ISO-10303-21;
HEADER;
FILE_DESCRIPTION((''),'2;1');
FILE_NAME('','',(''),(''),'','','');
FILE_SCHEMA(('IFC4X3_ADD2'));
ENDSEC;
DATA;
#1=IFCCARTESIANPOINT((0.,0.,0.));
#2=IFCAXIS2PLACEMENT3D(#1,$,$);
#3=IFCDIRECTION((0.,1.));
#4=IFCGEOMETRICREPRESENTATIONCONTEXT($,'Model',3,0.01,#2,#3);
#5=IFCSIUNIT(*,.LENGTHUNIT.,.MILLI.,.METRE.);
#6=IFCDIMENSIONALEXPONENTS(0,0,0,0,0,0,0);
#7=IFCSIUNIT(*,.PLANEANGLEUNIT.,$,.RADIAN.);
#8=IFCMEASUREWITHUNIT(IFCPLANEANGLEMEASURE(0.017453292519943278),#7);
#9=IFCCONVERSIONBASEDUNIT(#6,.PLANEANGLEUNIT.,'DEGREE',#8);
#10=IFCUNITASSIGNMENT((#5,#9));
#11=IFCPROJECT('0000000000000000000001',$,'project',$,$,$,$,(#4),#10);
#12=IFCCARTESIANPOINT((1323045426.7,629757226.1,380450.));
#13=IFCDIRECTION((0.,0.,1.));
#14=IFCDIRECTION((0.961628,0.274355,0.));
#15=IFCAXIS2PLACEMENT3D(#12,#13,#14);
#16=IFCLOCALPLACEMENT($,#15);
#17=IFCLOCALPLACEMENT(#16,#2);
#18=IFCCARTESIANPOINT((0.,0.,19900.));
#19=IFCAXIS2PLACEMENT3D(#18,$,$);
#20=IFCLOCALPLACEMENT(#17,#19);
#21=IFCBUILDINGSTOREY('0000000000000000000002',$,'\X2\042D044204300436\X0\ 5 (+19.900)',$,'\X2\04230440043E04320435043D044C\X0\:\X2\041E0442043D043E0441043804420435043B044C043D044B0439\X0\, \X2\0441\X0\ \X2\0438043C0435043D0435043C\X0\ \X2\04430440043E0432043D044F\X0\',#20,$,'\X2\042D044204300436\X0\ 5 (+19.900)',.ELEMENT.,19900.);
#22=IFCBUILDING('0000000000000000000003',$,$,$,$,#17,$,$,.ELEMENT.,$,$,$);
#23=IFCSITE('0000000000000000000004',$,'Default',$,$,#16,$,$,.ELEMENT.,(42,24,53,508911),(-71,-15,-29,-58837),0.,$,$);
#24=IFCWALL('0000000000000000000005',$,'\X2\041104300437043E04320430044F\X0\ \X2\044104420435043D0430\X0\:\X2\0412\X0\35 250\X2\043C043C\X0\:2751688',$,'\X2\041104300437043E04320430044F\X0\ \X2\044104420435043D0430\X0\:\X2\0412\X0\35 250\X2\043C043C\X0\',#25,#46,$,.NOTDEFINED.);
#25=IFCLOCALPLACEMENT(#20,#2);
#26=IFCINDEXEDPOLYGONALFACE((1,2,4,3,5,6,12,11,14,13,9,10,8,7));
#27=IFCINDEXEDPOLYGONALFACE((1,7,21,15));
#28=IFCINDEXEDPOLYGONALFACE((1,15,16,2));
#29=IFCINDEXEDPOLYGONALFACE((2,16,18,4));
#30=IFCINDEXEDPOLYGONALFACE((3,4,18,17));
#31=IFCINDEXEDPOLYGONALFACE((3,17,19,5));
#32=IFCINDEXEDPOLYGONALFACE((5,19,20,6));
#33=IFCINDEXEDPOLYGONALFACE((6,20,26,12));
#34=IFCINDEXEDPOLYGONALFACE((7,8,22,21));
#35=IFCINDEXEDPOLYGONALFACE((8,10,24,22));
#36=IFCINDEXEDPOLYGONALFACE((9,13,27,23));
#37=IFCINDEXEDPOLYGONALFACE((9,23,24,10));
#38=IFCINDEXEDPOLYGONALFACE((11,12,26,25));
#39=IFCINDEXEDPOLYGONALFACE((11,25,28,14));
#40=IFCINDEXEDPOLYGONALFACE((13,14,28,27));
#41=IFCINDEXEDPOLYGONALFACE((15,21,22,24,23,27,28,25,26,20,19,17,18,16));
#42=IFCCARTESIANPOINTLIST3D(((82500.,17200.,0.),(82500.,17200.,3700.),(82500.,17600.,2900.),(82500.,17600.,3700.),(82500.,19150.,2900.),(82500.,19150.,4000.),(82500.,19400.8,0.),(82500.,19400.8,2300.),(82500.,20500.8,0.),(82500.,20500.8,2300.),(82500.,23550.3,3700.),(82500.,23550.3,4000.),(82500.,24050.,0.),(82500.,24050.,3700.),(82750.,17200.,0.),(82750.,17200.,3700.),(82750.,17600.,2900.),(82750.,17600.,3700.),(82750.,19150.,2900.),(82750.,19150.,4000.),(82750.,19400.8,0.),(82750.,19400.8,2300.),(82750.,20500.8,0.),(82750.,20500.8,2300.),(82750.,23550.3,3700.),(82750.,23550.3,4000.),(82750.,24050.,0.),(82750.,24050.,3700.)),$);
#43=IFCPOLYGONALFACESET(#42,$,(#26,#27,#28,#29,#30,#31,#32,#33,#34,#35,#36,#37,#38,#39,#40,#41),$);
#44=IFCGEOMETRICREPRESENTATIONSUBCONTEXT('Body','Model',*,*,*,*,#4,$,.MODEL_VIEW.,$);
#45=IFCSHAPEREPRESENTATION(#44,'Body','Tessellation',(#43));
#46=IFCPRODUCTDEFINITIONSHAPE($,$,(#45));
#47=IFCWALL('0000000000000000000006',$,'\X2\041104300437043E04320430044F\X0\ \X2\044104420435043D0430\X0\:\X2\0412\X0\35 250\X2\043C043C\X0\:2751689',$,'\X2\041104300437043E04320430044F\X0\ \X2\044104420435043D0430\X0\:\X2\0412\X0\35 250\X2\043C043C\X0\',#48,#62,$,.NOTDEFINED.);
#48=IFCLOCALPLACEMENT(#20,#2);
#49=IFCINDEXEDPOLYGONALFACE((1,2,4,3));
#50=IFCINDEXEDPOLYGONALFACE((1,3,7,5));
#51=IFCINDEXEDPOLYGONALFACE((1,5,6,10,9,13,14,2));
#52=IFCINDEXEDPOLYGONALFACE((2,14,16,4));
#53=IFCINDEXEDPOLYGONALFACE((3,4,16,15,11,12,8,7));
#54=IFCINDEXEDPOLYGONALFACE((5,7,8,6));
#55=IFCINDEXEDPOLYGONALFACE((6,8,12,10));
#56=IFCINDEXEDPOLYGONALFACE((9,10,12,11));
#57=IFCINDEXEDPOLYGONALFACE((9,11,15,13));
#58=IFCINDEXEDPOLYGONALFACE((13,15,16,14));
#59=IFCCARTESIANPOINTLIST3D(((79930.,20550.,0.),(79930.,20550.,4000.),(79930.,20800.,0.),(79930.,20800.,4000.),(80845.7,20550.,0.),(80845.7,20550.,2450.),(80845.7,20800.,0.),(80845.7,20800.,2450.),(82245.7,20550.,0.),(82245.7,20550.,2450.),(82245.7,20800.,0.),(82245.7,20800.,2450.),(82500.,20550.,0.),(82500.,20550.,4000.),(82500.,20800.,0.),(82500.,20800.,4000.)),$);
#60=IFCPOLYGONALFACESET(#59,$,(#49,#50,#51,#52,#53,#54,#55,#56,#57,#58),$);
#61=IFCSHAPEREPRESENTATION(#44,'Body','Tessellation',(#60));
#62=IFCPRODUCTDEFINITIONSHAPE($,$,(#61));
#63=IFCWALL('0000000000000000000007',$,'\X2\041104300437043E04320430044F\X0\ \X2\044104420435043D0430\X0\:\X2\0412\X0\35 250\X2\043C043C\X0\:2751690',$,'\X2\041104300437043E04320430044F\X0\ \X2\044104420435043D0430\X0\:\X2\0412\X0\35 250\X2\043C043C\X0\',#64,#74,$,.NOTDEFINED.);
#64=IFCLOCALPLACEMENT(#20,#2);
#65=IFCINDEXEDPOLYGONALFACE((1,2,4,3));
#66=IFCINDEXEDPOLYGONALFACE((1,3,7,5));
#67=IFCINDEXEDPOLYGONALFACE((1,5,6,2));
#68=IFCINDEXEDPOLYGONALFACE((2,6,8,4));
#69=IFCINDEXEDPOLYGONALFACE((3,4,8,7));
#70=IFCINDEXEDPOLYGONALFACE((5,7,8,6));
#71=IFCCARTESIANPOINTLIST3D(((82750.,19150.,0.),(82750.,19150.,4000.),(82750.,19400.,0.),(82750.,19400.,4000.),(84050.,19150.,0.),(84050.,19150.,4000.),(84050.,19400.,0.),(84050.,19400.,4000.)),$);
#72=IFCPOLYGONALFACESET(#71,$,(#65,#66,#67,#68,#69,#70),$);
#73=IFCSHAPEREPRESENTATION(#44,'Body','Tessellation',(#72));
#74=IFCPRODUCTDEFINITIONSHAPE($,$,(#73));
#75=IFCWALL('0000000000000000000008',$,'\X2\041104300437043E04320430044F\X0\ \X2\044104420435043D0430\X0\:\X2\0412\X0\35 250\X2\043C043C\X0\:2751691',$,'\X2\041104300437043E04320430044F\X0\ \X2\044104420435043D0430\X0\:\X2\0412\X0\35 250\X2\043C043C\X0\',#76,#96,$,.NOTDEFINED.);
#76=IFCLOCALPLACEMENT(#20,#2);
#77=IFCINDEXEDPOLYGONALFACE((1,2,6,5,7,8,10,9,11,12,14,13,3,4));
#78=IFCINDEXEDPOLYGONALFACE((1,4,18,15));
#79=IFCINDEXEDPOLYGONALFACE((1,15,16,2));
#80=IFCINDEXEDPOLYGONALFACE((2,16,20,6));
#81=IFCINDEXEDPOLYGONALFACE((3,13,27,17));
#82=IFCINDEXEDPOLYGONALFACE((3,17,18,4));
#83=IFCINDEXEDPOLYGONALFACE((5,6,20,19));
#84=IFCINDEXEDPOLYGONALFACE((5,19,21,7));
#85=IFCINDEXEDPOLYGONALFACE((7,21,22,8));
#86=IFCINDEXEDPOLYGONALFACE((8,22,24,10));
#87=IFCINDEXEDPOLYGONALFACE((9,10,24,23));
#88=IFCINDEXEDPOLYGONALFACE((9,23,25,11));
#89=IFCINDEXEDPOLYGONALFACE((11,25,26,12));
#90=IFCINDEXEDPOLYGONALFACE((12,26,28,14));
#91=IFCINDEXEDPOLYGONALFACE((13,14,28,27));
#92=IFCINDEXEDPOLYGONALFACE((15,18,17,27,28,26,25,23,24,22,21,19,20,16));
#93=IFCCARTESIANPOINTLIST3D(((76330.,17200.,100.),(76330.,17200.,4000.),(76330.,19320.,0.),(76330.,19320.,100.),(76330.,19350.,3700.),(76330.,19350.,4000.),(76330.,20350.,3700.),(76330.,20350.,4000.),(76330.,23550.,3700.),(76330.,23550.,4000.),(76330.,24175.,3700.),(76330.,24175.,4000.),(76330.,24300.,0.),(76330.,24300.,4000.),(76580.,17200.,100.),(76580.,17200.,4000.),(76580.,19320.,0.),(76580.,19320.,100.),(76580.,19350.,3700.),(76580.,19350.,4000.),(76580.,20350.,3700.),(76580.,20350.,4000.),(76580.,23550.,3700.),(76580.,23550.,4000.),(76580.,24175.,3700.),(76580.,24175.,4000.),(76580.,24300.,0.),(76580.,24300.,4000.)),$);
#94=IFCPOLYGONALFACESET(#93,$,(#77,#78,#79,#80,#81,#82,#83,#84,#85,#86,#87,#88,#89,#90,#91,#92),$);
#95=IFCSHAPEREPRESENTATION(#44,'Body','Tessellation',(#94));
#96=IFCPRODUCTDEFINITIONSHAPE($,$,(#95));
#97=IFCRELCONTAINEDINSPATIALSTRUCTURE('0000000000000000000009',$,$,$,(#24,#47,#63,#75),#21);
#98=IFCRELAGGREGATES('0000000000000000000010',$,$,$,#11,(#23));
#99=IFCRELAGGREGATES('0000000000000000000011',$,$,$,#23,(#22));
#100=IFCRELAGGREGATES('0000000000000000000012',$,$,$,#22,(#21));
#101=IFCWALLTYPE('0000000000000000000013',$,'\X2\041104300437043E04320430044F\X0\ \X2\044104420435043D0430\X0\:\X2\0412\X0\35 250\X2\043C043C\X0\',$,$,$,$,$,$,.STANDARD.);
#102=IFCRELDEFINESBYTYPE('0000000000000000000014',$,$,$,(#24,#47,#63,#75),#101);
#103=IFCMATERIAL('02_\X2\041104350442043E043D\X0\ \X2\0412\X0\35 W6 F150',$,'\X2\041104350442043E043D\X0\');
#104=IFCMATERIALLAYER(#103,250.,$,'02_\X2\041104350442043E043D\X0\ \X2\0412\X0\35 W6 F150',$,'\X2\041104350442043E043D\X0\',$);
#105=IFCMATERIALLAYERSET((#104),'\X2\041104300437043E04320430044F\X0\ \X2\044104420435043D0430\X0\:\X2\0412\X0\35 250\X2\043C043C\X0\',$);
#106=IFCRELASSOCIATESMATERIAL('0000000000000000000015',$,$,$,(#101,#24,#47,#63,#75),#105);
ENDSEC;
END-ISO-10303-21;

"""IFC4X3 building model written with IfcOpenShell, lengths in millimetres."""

from ifc_helpers import new_model, entity, si_unit, converted_unit, direction, frame, frame_2d, origin, place, context, subcontext, project, spatial, rectangle, extrude, material, layer, layer_set, type_object, element, save


model = new_model("IFC4X3")

# Units and contexts
model_context = context("Model", 3, precision=0.01, world=origin(), true_north=direction((0.0, 1.0)))
body_context = subcontext(model_context, "Body", "Model", "MODEL_VIEW")
ifc_project = project(units=[si_unit("LENGTHUNIT", "METRE", prefix="MILLI"), converted_unit("PLANEANGLEUNIT", "DEGREE", entity("IfcPlaneAngleMeasure", 0.017453292519943278), si_unit("PLANEANGLEUNIT", "RADIAN"), dimensions=[0, 0, 0, 0, 0, 0, 0])], contexts=[model_context])

# Site, building, storey
site_placement = place(None, frame((1323045426.7, 629757226.1, 380450.0), z_axis=(0.0, 0.0, 1.0), x_axis=(0.961628, 0.274355, 0.0)))
site = spatial("IfcSite", under=ifc_project, at=site_placement, Name="Default", CompositionType="ELEMENT", RefLatitude=(42, 24, 53, 508911), RefLongitude=(-71, -15, -29, -58837), RefElevation=0.0)
building_placement = place(site_placement, origin())
building = spatial("IfcBuilding", under=site, at=building_placement, CompositionType="ELEMENT")
storey_placement = place(building_placement, frame((0.0, 0.0, 19900.0)))
storey = spatial("IfcBuildingStorey", under=building, at=storey_placement, Name="Этаж 5 (+19.900)", ObjectType="Уровень:Относительный, с именем уровня", LongName="Этаж 5 (+19.900)", CompositionType="ELEMENT", Elevation=19900.0)

# Shared definitions
ifc_material = material(Name="02_Бетон В35 W6 F150", Category="Бетон")

# Shared definitions
ifc_layer_1 = layer(ifc_material, 250.0, Name="02_Бетон В35 W6 F150", Category="Бетон")
ifc_layer_set_1 = layer_set([ifc_layer_1], Name="Базовая стена:В35 250мм")
wall_type_1 = type_object("IfcWallType", Name="Базовая стена:В35 250мм", PredefinedType="STANDARD", material=ifc_layer_set_1)

# Wall, openings
wall_1_placement = place(storey_placement, frame((82625.0, 24050.0, 0.0), z_axis=(0.0, 0.0, 1.0), x_axis=(0.0, -1.0, 0.0)))
wall_1 = element("IfcWall", 1, at=wall_1_placement, inside=storey, type_object=wall_type_1, material=ifc_layer_set_1, Name="Базовая стена:В35 250мм:2751688", ObjectType="Базовая стена:В35 250мм", PredefinedType="NOTDEFINED", context=body_context, shape_type="SweptSolid", body=[
    extrude(rectangle(XDim=6850.0, YDim=250.0, at=frame_2d((3425.0, 0.0), x_axis=(-1.0, 0.0))), origin(), (0.0, 0.0, 1.0), 4000.0),
])
opening_1_placement = place(wall_1_placement, origin())
element("IfcOpeningElement", 2, at=opening_1_placement, cuts=wall_1, PredefinedType="OPENING", context=body_context, shape_type="SweptSolid", body=[
    extrude(rectangle(XDim=300.0, YDim=525.3, at=frame_2d((0.0, 0.0), x_axis=(1.0, 0.0))), frame((6712.4, 125.0, 3850.0), z_axis=(0.0, -1.0, 0.0), x_axis=(0.0, 0.0, 1.0)), (0.0, 0.0, 1.0), 250.0),
])
opening_2_placement = place(wall_1_placement, origin())
element("IfcOpeningElement", 3, at=opening_2_placement, cuts=wall_1, PredefinedType="OPENING", context=body_context, shape_type="SweptSolid", body=[
    extrude(rectangle(XDim=300.0, YDim=624.7, at=frame_2d((0.0, 0.0), x_axis=(0.0, 1.0))), frame((187.4, 125.0, 3850.0), z_axis=(0.0, -1.0, 0.0), x_axis=(-1.0, 0.0, 0.0)), (0.0, 0.0, 1.0), 250.0),
])
opening_3_placement = place(wall_1_placement, frame((24050.0, -82625.0, 0.0), z_axis=(0.0, 0.0, 1.0), x_axis=(0.0, 1.0, 0.0)))
element("IfcOpeningElement", 4, at=opening_3_placement, cuts=wall_1, PredefinedType="OPENING", context=body_context, shape_type="SweptSolid", body=[
    extrude(rectangle(XDim=2300.0, YDim=1100.0, at=frame_2d((0.0, 0.0), x_axis=(0.0, 1.0))), frame((81226.0, 19950.8, 1150.0), z_axis=(1.0, 0.0, 0.0), x_axis=(0.0, -1.0, 0.0)), (0.0, 0.0, 1.0), 3048.0),
])
opening_4_placement = place(wall_1_placement, frame((24050.0, -82625.0, 2900.0), z_axis=(0.0, 0.0, 1.0), x_axis=(0.0, 1.0, 0.0)))
element("IfcOpeningElement", 5, at=opening_4_placement, cuts=wall_1, PredefinedType="OPENING", context=body_context, shape_type="SweptSolid", body=[
    extrude(rectangle(XDim=1100.0, YDim=1550.0, at=frame_2d((0.0, 0.0), x_axis=(1.0, 0.0))), frame((81226.0, 18375.0, 550.0), z_axis=(1.0, 0.0, 0.0), x_axis=(0.0, 0.0, -1.0)), (0.0, 0.0, 1.0), 3048.0),
])

# Wall, opening
wall_2_placement = place(storey_placement, frame((79930.0, 20675.0, 0.0)))
wall_2 = element("IfcWall", 6, at=wall_2_placement, inside=storey, type_object=wall_type_1, material=ifc_layer_set_1, Name="Базовая стена:В35 250мм:2751689", ObjectType="Базовая стена:В35 250мм", PredefinedType="NOTDEFINED", context=body_context, shape_type="SweptSolid", body=[
    extrude(rectangle(XDim=2570.0, YDim=250.0, at=frame_2d((1285.0, 0.0), x_axis=(-1.0, 0.0))), origin(), (0.0, 0.0, 1.0), 4000.0),
])
opening_5_placement = place(wall_2_placement, frame((-79930.0, -20675.0, 0.0)))
element("IfcOpeningElement", 7, at=opening_5_placement, cuts=wall_2, PredefinedType="OPENING", context=body_context, shape_type="SweptSolid", body=[
    extrude(rectangle(XDim=2450.0, YDim=1400.0, at=frame_2d((0.0, 0.0), x_axis=(0.0, 1.0))), frame((81545.7, 19276.0, 1225.0), z_axis=(0.0, 1.0, 0.0), x_axis=(1.0, 0.0, 0.0)), (0.0, 0.0, 1.0), 3048.0),
])

# Wall
wall_3_placement = place(storey_placement, frame((82750.0, 19275.0, 0.0)))
element("IfcWall", 8, at=wall_3_placement, inside=storey, type_object=wall_type_1, material=ifc_layer_set_1, Name="Базовая стена:В35 250мм:2751690", ObjectType="Базовая стена:В35 250мм", PredefinedType="NOTDEFINED", context=body_context, shape_type="SweptSolid", body=[
    extrude(rectangle(XDim=1300.0, YDim=250.0, at=frame_2d((650.0, 0.0), x_axis=(-1.0, 0.0))), origin(), (0.0, 0.0, 1.0), 4000.0),
])

# Wall, openings
wall_4_placement = place(storey_placement, frame((76455.0, 24300.0, 0.0), z_axis=(0.0, 0.0, 1.0), x_axis=(0.0, -1.0, 0.0)))
wall_4 = element("IfcWall", 9, at=wall_4_placement, inside=storey, type_object=wall_type_1, material=ifc_layer_set_1, Name="Базовая стена:В35 250мм:2751691", ObjectType="Базовая стена:В35 250мм", PredefinedType="NOTDEFINED", context=body_context, shape_type="SweptSolid", body=[
    extrude(rectangle(XDim=7100.0, YDim=250.0, at=frame_2d((3550.0, 0.0), x_axis=(-1.0, 0.0))), origin(), (0.0, 0.0, 1.0), 4000.0),
])
opening_6_placement = place(wall_4_placement, origin())
element("IfcOpeningElement", 10, at=opening_6_placement, cuts=wall_4, PredefinedType="OPENING", context=body_context, shape_type="SweptSolid", body=[
    extrude(rectangle(XDim=300.0, YDim=1000.0, at=frame_2d((0.0, 0.0), x_axis=(1.0, 0.0))), frame((4450.0, 125.0, 3850.0), z_axis=(0.0, -1.0, 0.0), x_axis=(0.0, 0.0, -1.0)), (0.0, 0.0, 1.0), 250.0),
])
opening_7_placement = place(wall_4_placement, origin())
element("IfcOpeningElement", 11, at=opening_7_placement, cuts=wall_4, PredefinedType="OPENING", context=body_context, shape_type="SweptSolid", body=[
    extrude(rectangle(XDim=100.0, YDim=2245.0, at=frame_2d((0.0, 0.0), x_axis=(0.0, 1.0))), frame((6102.5, 125.0, 50.0), z_axis=(0.0, -1.0, 0.0), x_axis=(-1.0, 0.0, 0.0)), (0.0, 0.0, 1.0), 250.0),
])
opening_8_placement = place(wall_4_placement, origin())
element("IfcOpeningElement", 12, at=opening_8_placement, cuts=wall_4, PredefinedType="OPENING", context=body_context, shape_type="SweptSolid", body=[
    extrude(rectangle(XDim=300.0, YDim=625.0, at=frame_2d((0.0, 0.0), x_axis=(0.0, 1.0))), frame((437.5, 125.0, 3850.0), z_axis=(0.0, -1.0, 0.0), x_axis=(1.0, 0.0, 0.0)), (0.0, 0.0, 1.0), 250.0),
])

save(model, "model.ifc")
